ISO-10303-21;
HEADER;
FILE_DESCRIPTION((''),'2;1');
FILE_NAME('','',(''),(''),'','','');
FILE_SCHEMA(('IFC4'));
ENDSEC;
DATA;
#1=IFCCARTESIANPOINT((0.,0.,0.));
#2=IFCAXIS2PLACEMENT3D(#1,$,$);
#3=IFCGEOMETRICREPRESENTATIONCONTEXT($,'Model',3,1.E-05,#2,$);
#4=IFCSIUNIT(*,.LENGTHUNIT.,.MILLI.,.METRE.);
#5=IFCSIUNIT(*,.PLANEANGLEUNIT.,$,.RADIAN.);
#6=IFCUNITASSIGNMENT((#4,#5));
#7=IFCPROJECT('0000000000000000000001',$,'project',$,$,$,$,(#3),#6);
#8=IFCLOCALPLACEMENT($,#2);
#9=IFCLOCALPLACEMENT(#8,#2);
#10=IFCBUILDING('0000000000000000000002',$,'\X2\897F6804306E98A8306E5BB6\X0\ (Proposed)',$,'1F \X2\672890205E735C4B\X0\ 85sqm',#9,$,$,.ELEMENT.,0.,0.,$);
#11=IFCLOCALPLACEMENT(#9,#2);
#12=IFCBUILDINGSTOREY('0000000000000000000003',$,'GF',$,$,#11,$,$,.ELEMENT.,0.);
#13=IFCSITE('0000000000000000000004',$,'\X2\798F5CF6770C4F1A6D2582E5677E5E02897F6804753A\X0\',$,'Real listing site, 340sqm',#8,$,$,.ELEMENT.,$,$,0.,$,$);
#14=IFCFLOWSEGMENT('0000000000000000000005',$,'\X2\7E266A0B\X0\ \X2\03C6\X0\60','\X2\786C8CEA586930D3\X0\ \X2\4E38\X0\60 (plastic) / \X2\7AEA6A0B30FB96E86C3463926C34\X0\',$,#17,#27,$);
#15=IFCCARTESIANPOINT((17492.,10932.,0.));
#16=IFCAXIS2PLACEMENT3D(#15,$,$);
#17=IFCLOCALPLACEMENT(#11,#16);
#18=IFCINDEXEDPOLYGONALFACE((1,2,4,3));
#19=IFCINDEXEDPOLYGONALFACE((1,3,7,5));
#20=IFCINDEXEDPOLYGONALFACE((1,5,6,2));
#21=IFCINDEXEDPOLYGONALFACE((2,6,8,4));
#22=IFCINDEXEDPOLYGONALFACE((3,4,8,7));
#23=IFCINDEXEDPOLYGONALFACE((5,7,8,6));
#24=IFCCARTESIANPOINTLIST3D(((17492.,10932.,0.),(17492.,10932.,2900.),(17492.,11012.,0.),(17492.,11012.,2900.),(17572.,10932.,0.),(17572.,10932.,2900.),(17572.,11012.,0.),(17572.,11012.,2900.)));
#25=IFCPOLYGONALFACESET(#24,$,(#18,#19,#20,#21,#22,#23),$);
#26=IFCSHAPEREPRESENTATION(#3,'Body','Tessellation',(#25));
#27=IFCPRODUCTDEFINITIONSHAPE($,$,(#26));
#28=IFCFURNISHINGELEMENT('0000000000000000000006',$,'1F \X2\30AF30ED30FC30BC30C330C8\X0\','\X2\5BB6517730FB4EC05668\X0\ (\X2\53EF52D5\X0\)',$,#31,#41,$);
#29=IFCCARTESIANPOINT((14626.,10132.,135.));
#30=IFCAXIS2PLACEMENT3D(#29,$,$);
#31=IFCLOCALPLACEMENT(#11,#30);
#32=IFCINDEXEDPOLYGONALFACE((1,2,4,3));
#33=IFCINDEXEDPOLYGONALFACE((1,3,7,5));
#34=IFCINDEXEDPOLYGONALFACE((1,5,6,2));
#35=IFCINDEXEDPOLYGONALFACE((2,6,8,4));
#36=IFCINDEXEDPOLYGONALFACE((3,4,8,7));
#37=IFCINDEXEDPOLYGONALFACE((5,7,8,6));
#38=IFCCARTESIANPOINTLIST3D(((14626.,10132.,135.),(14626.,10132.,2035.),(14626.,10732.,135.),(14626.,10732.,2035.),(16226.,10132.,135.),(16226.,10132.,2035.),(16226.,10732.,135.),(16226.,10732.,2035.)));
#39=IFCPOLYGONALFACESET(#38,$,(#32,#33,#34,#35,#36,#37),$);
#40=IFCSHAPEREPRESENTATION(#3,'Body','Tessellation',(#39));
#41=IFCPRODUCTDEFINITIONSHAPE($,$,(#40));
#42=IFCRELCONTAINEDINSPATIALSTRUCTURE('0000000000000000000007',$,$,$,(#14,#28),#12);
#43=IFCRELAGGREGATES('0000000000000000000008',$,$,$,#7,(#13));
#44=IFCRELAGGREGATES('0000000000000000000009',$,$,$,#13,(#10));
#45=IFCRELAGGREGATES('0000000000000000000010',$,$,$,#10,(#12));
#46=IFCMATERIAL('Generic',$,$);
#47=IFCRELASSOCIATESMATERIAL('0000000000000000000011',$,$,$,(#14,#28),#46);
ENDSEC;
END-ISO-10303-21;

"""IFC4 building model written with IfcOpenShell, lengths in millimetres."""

from ifc_helpers import new_model, si_unit, frame, frame_2d, origin, place, context, project, spatial, rectangle, extrude, material, element, save


model = new_model("IFC4")

# Units and contexts
model_context = context("Model", 3, precision=1e-05, world=origin())
ifc_project = project(units=[si_unit("LENGTHUNIT", "METRE", prefix="MILLI"), si_unit("PLANEANGLEUNIT", "RADIAN")], contexts=[model_context])

# Site, building, storey
site_placement = place(None, origin())
site = spatial("IfcSite", under=ifc_project, at=site_placement, Name="福島県会津若松市西栄町", ObjectType="Real listing site, 340sqm", CompositionType="ELEMENT", RefElevation=0.0)
building_placement = place(site_placement, origin())
building = spatial("IfcBuilding", under=site, at=building_placement, Name="西栄の風の家 (Proposed)", ObjectType="1F 木造平屋 85sqm", CompositionType="ELEMENT", ElevationOfRefHeight=0.0, ElevationOfTerrain=0.0)
storey_placement = place(building_placement, origin())
storey = spatial("IfcBuildingStorey", under=building, at=storey_placement, Name="GF", CompositionType="ELEMENT", Elevation=0.0)

# Shared definitions
ifc_material_1 = material(Name="Generic")

# Flow segment
flow_segment_placement = place(storey_placement, frame((17492.0, 10932.0, 0.0)))
element("IfcFlowSegment", 1, at=flow_segment_placement, inside=storey, material=ifc_material_1, Name="縦樋 φ60", Description="硬質塩ビ 丸60 (plastic) / 竪樋・雨水排水", context=model_context, shape_type="SweptSolid", body=[
    extrude(rectangle(XDim=80.0, YDim=80.0, at=frame_2d((40.0, 40.0))), frame((17492.0, 10932.0, 0.0)), (0.0, 0.0, 1.0), 2900.0),
])

# Furnishing element
furnishing_placement = place(storey_placement, frame((14626.0, 10132.0, 135.0)))
element("IfcFurnishingElement", 2, at=furnishing_placement, inside=storey, material=ifc_material_1, Name="1F クローゼット", Description="家具・什器 (可動)", context=model_context, shape_type="SweptSolid", body=[
    extrude(rectangle(XDim=1600.0, YDim=600.0, at=frame_2d((800.0, 300.0))), frame((14626.0, 10132.0, 135.0)), (0.0, 0.0, 1.0), 1900.0),
])

save(model, "model.ifc")
